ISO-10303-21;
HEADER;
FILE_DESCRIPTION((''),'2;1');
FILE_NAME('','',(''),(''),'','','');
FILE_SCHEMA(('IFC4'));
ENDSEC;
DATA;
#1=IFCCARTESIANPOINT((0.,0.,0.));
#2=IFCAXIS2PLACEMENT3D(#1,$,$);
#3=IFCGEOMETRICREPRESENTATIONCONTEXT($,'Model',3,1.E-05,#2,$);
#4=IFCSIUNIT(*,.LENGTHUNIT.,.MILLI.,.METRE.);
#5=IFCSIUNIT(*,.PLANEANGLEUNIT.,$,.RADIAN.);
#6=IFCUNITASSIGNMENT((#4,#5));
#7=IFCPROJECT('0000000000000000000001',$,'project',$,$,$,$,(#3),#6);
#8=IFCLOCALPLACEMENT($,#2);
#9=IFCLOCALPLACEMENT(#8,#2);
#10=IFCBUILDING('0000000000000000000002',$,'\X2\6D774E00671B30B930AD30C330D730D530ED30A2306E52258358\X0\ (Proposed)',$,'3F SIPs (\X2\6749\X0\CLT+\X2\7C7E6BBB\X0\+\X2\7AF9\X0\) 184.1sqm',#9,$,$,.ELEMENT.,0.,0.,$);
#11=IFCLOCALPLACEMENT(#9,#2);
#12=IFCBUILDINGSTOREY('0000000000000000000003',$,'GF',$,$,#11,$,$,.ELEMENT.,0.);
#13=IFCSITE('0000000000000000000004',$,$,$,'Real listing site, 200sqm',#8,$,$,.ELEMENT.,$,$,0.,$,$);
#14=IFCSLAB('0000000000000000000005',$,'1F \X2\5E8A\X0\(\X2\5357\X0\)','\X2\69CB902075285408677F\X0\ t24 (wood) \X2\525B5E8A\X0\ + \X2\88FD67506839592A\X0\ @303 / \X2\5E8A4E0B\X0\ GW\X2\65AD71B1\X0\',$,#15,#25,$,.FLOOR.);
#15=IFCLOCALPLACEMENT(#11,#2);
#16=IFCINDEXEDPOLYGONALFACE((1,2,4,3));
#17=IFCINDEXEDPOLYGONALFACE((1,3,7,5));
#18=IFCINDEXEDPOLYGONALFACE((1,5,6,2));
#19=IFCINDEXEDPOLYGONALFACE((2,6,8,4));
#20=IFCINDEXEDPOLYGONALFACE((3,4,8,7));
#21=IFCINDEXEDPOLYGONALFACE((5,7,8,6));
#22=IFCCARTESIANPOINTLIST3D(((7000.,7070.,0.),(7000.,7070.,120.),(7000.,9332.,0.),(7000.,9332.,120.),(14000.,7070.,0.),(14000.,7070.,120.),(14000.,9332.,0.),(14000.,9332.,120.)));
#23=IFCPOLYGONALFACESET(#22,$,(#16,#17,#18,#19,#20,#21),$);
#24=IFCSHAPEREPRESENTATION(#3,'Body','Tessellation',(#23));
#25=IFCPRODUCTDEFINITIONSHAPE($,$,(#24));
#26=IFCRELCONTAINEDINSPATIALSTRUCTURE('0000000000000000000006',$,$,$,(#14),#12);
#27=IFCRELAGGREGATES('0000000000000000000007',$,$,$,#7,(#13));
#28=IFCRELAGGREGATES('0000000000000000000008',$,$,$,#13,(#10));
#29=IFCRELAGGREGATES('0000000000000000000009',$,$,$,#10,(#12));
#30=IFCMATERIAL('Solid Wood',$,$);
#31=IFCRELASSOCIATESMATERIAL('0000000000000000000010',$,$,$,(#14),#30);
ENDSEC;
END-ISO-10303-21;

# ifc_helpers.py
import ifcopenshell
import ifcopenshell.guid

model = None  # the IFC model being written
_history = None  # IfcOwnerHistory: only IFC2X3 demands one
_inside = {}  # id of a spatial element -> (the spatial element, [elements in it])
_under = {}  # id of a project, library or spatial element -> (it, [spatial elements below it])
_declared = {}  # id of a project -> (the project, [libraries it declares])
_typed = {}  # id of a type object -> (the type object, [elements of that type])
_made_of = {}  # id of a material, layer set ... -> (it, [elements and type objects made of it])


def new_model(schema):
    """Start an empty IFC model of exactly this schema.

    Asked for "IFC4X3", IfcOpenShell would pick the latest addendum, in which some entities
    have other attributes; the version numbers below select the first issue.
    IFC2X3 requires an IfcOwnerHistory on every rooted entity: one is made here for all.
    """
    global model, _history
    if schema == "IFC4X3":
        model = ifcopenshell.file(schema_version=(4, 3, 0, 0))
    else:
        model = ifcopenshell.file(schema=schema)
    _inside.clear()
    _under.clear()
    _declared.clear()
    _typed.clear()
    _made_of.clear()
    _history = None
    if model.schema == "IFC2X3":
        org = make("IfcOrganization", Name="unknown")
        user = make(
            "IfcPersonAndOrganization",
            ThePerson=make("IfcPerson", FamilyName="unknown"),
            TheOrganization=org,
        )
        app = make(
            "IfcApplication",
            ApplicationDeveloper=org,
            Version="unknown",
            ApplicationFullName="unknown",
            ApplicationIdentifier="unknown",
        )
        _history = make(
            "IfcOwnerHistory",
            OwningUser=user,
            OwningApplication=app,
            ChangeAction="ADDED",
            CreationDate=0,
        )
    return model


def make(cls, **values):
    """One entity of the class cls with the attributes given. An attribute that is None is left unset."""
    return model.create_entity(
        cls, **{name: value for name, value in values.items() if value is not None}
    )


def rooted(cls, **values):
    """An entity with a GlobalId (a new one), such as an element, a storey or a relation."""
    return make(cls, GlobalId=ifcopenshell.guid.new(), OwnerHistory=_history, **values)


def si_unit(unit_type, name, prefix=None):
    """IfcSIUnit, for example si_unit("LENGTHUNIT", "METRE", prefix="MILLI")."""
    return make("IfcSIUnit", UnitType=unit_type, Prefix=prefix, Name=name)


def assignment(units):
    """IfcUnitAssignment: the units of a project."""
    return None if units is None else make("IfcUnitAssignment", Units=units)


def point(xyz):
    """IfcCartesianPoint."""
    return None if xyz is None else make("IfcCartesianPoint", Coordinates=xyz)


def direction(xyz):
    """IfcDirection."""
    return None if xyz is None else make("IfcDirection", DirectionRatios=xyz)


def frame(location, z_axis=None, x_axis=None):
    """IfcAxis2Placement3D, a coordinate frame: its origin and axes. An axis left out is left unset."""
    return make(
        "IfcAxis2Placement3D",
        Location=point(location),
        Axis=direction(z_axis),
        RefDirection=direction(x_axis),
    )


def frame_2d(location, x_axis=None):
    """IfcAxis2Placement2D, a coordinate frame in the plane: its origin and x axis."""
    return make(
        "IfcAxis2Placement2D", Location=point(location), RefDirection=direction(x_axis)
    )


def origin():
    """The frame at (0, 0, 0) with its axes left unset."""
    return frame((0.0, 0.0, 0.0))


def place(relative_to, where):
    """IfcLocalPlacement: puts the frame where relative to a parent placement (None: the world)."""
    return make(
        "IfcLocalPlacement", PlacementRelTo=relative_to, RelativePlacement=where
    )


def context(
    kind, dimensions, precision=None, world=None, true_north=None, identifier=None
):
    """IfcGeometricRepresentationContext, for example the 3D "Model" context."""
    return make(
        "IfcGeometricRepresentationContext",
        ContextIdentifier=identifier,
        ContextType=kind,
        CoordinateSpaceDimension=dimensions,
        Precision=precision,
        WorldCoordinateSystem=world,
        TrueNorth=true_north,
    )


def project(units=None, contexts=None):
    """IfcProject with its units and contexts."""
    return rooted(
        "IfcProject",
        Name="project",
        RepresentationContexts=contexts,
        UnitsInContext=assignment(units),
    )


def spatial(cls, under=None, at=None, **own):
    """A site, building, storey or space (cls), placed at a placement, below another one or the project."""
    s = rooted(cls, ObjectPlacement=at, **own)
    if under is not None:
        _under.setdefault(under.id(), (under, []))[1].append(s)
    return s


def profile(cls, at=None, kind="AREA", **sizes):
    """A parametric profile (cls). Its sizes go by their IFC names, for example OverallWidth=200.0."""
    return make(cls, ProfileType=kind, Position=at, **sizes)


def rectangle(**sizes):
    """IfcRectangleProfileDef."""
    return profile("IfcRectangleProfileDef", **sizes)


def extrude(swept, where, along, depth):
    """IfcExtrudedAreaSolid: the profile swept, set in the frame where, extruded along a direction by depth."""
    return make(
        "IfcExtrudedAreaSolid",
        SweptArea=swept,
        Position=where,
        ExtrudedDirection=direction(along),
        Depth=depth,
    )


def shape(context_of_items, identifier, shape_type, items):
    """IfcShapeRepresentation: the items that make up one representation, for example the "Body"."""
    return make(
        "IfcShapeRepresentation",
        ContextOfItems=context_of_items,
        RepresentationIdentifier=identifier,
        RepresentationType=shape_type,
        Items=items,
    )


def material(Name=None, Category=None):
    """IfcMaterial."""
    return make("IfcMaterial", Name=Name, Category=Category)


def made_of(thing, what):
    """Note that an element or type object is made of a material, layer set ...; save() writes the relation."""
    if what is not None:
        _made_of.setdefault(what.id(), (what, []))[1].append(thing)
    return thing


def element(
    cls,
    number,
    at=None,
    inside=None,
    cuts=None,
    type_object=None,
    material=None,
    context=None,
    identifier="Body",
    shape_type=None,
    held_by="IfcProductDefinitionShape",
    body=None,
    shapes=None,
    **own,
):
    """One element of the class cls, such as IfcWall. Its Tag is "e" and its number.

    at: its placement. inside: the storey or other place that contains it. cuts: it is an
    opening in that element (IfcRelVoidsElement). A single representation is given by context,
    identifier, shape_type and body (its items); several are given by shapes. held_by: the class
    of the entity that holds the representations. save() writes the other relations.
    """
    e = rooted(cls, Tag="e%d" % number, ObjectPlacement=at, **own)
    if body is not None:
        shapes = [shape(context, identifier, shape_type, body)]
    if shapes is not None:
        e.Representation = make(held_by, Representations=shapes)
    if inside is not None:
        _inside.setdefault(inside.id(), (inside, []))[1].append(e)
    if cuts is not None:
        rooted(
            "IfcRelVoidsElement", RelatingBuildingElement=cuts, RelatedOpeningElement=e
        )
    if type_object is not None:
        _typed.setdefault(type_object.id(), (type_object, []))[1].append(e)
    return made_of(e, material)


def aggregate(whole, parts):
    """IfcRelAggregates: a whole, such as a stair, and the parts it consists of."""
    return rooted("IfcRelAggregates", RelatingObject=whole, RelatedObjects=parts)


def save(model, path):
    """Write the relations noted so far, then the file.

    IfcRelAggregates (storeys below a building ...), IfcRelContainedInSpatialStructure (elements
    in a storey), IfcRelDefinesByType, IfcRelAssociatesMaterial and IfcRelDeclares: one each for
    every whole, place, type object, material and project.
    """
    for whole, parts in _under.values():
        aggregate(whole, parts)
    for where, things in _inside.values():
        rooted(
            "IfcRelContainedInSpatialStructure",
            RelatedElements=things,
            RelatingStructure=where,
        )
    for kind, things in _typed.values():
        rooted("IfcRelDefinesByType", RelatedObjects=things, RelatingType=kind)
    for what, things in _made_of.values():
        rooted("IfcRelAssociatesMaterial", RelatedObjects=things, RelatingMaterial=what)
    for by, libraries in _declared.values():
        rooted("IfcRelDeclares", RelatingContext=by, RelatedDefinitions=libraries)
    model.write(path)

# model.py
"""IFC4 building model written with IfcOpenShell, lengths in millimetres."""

from ifc_helpers import new_model, si_unit, frame, frame_2d, origin, place, context, project, spatial, rectangle, extrude, material, element, save


model = new_model("IFC4")

# Units and contexts
model_context = context("Model", 3, precision=1e-05, world=origin())
ifc_project = project(units=[si_unit("LENGTHUNIT", "METRE", prefix="MILLI"), si_unit("PLANEANGLEUNIT", "RADIAN")], contexts=[model_context])

# Site, building, storey
site_placement = place(None, origin())
site = spatial("IfcSite", under=ifc_project, at=site_placement, ObjectType="Real listing site, 200sqm", CompositionType="ELEMENT", RefElevation=0.0)
building_placement = place(site_placement, origin())
building = spatial("IfcBuilding", under=site, at=building_placement, Name="海一望スキップフロアの別荘 (Proposed)", ObjectType="3F SIPs (杉CLT+籾殻+竹) 184.1sqm", CompositionType="ELEMENT", ElevationOfRefHeight=0.0, ElevationOfTerrain=0.0)
storey_placement = place(building_placement, origin())
storey = spatial("IfcBuildingStorey", under=building, at=storey_placement, Name="GF", CompositionType="ELEMENT", Elevation=0.0)

# Slab
ifc_material_1 = material(Name="Solid Wood")
slab_1_placement = place(storey_placement, frame((3500.0, 3535.0, 0.0)))
element("IfcSlab", 1, at=slab_1_placement, inside=storey, material=ifc_material_1, Name="1F 床(南)", Description="構造用合板 t24 (wood) 剛床 + 製材根太 @303 / 床下 GW断熱", PredefinedType="FLOOR", context=model_context, shape_type="SweptSolid", body=[
    extrude(rectangle(XDim=7000.0, YDim=2262.0, at=frame_2d((3500.0, 1131.0))), frame((3500.0, 3535.0, 0.0)), (0.0, 0.0, 1.0), 120.0),
])

save(model, "model.ifc")
